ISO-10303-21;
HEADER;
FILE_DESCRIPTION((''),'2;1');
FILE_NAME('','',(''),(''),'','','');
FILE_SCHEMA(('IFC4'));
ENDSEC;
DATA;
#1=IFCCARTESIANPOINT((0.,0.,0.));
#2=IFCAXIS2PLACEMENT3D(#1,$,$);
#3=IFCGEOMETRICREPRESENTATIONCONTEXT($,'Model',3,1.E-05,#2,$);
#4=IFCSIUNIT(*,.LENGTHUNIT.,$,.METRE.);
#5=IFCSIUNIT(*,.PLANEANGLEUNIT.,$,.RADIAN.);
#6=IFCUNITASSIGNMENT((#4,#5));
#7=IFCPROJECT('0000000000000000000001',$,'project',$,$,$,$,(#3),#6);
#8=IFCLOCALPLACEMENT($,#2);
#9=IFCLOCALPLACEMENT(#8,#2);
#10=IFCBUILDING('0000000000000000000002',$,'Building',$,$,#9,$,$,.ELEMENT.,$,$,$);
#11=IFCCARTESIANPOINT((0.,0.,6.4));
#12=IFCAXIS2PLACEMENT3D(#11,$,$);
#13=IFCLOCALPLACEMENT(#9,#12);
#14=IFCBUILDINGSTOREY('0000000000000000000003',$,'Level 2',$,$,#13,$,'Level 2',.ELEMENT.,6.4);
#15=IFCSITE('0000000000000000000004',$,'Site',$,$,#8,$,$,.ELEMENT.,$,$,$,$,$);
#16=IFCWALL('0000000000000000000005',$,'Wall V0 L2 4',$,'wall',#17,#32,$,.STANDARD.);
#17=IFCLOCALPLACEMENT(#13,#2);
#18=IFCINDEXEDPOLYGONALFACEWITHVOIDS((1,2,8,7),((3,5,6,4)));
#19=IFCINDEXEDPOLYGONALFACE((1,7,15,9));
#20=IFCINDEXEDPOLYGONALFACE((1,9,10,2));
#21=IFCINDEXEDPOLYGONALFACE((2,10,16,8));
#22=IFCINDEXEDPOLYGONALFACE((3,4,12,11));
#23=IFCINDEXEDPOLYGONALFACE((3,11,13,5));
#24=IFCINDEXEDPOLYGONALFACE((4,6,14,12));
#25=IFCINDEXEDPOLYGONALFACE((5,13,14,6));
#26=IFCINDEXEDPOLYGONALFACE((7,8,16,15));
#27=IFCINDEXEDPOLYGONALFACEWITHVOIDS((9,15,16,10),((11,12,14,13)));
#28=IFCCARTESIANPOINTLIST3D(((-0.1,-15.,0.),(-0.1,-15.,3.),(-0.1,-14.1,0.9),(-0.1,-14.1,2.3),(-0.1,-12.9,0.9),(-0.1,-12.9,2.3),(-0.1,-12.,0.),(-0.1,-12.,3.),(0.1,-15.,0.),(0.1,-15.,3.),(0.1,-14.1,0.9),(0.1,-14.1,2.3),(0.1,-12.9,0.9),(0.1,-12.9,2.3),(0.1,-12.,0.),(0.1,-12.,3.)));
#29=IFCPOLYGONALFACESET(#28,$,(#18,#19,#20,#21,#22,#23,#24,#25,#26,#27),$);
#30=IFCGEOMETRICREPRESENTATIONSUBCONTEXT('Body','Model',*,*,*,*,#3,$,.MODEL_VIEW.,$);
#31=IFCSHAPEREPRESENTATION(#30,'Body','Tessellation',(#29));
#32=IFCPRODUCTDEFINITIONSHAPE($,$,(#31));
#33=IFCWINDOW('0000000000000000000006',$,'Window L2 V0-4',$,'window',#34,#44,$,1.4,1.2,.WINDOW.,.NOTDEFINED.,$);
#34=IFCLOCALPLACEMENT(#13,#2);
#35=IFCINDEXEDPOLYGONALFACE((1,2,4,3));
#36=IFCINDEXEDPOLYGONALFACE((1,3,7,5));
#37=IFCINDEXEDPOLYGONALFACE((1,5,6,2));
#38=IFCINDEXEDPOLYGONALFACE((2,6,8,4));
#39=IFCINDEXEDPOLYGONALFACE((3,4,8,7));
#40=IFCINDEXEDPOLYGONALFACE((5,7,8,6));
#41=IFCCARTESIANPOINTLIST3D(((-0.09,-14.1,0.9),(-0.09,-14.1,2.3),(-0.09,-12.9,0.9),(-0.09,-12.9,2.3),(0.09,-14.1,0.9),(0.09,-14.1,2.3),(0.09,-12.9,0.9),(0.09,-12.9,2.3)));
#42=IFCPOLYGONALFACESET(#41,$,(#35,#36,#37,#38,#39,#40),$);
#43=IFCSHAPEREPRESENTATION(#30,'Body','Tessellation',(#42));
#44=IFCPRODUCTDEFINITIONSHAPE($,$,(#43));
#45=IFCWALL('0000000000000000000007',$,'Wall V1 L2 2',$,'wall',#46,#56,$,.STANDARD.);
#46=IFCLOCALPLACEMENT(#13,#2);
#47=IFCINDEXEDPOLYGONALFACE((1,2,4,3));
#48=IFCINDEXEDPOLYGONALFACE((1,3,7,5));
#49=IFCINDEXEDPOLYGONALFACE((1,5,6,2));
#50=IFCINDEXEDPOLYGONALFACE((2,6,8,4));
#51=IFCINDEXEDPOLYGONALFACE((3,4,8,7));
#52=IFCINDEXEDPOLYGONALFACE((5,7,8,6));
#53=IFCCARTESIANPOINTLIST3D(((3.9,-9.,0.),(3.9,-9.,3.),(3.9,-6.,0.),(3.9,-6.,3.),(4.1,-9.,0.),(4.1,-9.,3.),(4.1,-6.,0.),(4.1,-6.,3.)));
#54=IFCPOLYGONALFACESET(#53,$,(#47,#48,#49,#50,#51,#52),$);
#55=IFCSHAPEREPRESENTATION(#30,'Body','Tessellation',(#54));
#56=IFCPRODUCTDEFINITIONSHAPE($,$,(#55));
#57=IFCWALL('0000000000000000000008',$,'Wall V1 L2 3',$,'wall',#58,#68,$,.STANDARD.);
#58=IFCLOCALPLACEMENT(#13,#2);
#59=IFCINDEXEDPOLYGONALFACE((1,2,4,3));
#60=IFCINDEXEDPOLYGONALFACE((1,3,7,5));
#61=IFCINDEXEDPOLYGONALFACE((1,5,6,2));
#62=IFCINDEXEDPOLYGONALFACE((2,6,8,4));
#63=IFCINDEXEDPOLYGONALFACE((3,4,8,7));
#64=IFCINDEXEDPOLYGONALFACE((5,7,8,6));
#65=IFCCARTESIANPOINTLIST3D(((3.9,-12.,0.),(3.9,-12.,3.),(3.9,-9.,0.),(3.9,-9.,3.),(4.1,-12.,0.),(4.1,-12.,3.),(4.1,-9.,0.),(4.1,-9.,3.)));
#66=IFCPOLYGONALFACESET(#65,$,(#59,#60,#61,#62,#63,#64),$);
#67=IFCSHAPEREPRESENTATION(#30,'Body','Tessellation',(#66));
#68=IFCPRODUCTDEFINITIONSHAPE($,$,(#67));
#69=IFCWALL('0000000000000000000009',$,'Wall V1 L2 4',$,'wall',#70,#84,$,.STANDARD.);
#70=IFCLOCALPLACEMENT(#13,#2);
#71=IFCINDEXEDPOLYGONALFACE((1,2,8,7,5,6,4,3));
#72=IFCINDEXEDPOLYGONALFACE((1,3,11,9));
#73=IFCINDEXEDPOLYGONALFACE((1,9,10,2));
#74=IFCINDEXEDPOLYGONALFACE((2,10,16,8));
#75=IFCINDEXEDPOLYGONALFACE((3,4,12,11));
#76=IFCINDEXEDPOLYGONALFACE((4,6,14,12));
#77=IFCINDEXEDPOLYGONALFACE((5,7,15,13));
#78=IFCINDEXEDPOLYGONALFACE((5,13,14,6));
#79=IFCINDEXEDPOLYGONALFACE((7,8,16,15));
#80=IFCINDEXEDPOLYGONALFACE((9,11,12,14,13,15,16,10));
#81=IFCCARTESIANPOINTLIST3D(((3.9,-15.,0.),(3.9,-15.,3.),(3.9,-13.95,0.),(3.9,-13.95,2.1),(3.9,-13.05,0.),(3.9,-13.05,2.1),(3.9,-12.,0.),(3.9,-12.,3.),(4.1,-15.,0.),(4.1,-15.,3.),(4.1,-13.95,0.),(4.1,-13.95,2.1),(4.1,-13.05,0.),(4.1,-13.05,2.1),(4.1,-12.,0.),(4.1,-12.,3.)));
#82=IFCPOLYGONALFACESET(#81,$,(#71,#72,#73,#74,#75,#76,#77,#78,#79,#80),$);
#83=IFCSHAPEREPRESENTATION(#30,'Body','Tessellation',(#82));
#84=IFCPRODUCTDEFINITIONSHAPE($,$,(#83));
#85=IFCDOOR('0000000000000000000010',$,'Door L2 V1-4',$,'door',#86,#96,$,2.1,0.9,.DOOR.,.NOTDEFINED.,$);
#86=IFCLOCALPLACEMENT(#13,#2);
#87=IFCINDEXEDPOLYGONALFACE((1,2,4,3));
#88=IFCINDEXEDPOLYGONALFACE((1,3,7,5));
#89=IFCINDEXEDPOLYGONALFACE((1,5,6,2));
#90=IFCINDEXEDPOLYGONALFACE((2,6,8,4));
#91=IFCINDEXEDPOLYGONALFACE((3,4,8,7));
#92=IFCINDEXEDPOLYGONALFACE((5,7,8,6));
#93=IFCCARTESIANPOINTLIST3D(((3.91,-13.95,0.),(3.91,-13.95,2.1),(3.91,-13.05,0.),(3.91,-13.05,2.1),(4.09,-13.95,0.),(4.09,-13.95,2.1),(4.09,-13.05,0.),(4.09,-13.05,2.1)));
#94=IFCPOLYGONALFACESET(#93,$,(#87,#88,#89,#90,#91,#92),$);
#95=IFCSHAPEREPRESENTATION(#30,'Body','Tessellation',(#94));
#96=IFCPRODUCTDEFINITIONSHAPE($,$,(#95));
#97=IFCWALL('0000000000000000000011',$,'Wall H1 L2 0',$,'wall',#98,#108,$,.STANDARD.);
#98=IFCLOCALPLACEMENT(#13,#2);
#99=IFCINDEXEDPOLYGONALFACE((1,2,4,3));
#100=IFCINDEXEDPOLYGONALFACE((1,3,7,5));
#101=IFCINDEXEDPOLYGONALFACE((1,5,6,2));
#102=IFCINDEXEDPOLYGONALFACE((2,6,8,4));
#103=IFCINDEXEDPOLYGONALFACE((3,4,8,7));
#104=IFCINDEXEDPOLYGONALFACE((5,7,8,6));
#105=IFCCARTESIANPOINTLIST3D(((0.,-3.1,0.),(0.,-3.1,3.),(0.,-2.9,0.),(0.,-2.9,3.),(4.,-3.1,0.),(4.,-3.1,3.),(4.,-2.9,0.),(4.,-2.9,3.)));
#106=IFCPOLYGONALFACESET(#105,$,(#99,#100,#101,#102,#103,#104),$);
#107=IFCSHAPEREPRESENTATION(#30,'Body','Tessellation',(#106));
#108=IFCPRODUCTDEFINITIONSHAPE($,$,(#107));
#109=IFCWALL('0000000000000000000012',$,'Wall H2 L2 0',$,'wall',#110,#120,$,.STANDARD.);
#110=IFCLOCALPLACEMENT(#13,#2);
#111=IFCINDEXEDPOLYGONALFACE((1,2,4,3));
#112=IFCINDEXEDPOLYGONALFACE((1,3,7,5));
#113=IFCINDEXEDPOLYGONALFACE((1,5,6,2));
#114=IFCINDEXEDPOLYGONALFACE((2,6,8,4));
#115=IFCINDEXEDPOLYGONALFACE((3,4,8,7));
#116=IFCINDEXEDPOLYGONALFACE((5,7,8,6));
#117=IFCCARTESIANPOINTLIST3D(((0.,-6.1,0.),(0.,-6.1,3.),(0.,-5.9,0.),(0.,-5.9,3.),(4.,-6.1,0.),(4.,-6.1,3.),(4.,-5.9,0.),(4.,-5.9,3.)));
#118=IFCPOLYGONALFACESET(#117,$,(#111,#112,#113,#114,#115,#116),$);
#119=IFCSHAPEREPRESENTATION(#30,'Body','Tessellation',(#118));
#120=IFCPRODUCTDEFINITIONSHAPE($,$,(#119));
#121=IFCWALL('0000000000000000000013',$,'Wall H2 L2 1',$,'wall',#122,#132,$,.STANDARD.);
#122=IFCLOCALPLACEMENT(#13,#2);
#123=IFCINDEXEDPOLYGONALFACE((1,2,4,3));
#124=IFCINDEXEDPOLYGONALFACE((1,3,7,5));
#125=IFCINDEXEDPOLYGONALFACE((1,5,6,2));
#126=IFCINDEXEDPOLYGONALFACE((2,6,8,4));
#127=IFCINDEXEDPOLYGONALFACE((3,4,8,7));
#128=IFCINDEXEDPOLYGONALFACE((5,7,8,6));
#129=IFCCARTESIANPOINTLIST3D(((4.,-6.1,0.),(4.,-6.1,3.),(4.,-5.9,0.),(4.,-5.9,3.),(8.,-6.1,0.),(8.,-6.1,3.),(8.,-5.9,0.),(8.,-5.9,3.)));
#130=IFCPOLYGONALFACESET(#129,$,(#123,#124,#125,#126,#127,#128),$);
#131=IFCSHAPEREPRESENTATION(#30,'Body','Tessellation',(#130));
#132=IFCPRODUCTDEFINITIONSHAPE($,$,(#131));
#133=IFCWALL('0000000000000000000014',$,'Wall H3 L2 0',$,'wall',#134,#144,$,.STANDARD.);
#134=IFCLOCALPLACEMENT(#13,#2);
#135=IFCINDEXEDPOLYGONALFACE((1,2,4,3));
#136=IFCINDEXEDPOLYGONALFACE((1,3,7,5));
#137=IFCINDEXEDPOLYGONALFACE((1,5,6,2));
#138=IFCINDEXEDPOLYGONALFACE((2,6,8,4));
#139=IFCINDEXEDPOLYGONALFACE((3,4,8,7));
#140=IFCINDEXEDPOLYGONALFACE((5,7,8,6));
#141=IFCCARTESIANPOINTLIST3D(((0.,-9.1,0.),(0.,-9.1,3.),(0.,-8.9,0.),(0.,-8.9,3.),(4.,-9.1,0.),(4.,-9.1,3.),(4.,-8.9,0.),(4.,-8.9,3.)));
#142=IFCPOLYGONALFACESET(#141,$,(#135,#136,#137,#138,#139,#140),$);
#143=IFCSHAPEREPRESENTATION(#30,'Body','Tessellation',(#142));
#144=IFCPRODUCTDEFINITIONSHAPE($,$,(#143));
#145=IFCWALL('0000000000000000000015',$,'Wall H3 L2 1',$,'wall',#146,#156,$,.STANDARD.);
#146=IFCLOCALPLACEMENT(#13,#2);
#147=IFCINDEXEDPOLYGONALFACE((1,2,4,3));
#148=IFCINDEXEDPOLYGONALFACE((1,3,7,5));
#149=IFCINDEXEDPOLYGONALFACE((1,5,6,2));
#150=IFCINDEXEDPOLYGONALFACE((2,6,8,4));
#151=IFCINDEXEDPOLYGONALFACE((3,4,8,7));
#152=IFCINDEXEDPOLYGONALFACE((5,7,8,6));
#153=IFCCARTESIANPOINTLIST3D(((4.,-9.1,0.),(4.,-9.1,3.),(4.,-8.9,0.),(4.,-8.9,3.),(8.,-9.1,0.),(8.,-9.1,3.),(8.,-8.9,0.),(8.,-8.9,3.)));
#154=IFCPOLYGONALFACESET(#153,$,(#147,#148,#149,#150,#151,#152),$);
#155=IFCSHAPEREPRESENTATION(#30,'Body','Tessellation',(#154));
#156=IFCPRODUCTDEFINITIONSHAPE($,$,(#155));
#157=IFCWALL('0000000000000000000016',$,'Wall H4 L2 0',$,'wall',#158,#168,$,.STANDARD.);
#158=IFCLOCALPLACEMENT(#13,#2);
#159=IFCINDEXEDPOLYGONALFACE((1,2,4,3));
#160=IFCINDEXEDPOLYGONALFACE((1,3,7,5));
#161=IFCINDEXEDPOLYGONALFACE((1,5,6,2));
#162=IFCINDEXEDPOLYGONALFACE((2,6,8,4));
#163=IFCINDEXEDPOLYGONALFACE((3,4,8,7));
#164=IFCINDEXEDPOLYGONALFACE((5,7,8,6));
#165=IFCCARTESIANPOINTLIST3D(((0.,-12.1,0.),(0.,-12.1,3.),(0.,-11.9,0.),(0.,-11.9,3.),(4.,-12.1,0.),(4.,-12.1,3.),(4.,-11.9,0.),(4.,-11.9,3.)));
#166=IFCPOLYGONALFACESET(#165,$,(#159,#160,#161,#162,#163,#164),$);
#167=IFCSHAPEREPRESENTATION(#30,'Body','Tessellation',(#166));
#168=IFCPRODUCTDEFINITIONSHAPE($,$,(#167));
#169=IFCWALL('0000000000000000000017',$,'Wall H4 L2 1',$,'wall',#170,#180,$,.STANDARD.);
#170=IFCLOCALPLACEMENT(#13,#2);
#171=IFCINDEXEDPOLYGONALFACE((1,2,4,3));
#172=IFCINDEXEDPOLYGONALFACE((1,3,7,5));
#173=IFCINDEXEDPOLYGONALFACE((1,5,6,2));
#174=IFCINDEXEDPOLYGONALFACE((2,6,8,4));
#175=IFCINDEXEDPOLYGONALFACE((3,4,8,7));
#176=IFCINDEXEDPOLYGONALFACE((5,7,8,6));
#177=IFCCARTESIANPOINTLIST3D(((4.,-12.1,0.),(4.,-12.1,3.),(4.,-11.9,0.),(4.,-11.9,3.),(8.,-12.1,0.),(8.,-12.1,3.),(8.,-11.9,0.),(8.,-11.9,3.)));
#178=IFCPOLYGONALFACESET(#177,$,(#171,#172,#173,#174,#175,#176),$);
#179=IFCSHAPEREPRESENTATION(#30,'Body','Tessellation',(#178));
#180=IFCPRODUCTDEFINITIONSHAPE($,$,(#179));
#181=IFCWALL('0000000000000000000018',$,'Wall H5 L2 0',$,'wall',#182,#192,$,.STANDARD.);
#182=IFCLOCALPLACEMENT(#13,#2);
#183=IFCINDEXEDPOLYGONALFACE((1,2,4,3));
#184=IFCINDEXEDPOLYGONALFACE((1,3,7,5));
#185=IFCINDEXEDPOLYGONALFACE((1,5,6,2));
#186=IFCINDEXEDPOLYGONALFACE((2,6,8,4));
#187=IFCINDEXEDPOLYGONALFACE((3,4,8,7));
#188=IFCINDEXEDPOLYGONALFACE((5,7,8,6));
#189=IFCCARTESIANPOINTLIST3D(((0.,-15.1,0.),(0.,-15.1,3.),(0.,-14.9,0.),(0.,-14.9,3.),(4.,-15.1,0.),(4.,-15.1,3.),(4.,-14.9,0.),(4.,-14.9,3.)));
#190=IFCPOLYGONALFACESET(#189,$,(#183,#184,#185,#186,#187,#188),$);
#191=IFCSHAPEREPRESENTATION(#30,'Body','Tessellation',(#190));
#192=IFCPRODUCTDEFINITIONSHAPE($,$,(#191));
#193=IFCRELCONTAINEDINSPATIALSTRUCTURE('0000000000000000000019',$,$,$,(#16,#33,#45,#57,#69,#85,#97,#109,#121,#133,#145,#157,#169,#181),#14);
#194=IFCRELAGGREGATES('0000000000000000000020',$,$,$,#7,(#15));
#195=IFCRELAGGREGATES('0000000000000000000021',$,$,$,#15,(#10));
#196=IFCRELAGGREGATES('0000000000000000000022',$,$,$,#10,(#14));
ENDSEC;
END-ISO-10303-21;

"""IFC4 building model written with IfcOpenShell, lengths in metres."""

from ifc_helpers import new_model, si_unit, frame, frame_2d, origin, origin_2d, place, context, subcontext, project, spatial, rectangle, extrude, element, fill, save


model = new_model("IFC4")

# Units and contexts
model_context = context("Model", 3, precision=1e-05, world=origin())
body_context = subcontext(model_context, "Body", "Model", "MODEL_VIEW")
ifc_project = project(units=[si_unit("LENGTHUNIT", "METRE"), si_unit("PLANEANGLEUNIT", "RADIAN")], contexts=[model_context])

# Site, building, storey
site_placement = place(None, origin())
site = spatial("IfcSite", under=ifc_project, at=site_placement, Name="Site", CompositionType="ELEMENT")
building_placement = place(site_placement, origin())
building = spatial("IfcBuilding", under=site, at=building_placement, Name="Building", CompositionType="ELEMENT")
storey_placement = place(building_placement, frame((0.0, 0.0, 6.4)))
storey = spatial("IfcBuildingStorey", under=building, at=storey_placement, Name="Level 2", LongName="Level 2", CompositionType="ELEMENT", Elevation=6.4)

# Wall, opening, window
wall_1_placement = place(storey_placement, frame((0.0, -12.0, 0.0), z_axis=(0.0, 0.0, 1.0), x_axis=(0.0, -1.0, 0.0)))
wall_1 = element("IfcWall", 1, at=wall_1_placement, inside=storey, Name="Wall V0 L2 4", ObjectType="wall", PredefinedType="STANDARD", context=body_context, shape_type="SweptSolid", body=[
    extrude(rectangle(XDim=3.0, YDim=0.2, at=frame_2d((1.5, 0.0))), origin(), (0.0, 0.0, 1.0), 3.0),
])
opening_1_placement = place(storey_placement, frame((0.0, -13.5, 0.9), z_axis=(0.0, 0.0, 1.0), x_axis=(0.0, -1.0, 0.0)))
opening_1 = element("IfcOpeningElement", 2, at=opening_1_placement, cuts=wall_1, ObjectType="Opening", PredefinedType="OPENING", context=body_context, shape_type="SweptSolid", body=[
    extrude(rectangle(XDim=1.2, YDim=0.22, at=origin_2d()), origin(), (0.0, 0.0, 1.0), 1.4),
])
window_1_placement = place(storey_placement, frame((0.0, -13.5, 0.9), z_axis=(0.0, 0.0, 1.0), x_axis=(0.0, -1.0, 0.0)))
window_1 = element("IfcWindow", 3, at=window_1_placement, inside=storey, Name="Window L2 V0-4", ObjectType="window", OverallHeight=1.4, OverallWidth=1.2, PartitioningType="NOTDEFINED", PredefinedType="WINDOW", context=body_context, shape_type="SweptSolid", body=[
    extrude(rectangle(XDim=1.2, YDim=0.18, at=origin_2d()), origin(), (0.0, 0.0, 1.0), 1.4),
])
fill(opening_1, window_1)

# Walls
for number, where, z_axis, x_axis, name in (
    (4, (4.0, -6.0, 0.0), (0.0, 0.0, 1.0), (0.0, -1.0, 0.0), "Wall V1 L2 2"),
    (5, (4.0, -9.0, 0.0), (0.0, 0.0, 1.0), (0.0, -1.0, 0.0), "Wall V1 L2 3"),
):
    element("IfcWall", number, at=place(storey_placement, frame(where, z_axis=z_axis, x_axis=x_axis)), inside=storey, Name=name, ObjectType="wall", PredefinedType="STANDARD", context=body_context, shape_type="SweptSolid", body=[
        extrude(rectangle(XDim=3.0, YDim=0.2, at=frame_2d((1.5, 0.0))), origin(), (0.0, 0.0, 1.0), 3.0),
    ])

# Wall, opening, door
wall_2_placement = place(storey_placement, frame((4.0, -12.0, 0.0), z_axis=(0.0, 0.0, 1.0), x_axis=(0.0, -1.0, 0.0)))
wall_2 = element("IfcWall", 6, at=wall_2_placement, inside=storey, Name="Wall V1 L2 4", ObjectType="wall", PredefinedType="STANDARD", context=body_context, shape_type="SweptSolid", body=[
    extrude(rectangle(XDim=3.0, YDim=0.2, at=frame_2d((1.5, 0.0))), origin(), (0.0, 0.0, 1.0), 3.0),
])
opening_2_placement = place(storey_placement, frame((4.0, -13.5, 0.0), z_axis=(0.0, 0.0, 1.0), x_axis=(0.0, -1.0, 0.0)))
opening_2 = element("IfcOpeningElement", 7, at=opening_2_placement, cuts=wall_2, ObjectType="Opening", PredefinedType="OPENING", context=body_context, shape_type="SweptSolid", body=[
    extrude(rectangle(XDim=0.9, YDim=0.22, at=origin_2d()), origin(), (0.0, 0.0, 1.0), 2.1),
])
door_placement = place(storey_placement, frame((4.0, -13.5, 0.0), z_axis=(0.0, 0.0, 1.0), x_axis=(0.0, -1.0, 0.0)))
door = element("IfcDoor", 8, at=door_placement, inside=storey, Name="Door L2 V1-4", ObjectType="door", OperationType="NOTDEFINED", OverallHeight=2.1, OverallWidth=0.9, PredefinedType="DOOR", context=body_context, shape_type="SweptSolid", body=[
    extrude(rectangle(XDim=0.9, YDim=0.18, at=origin_2d()), origin(), (0.0, 0.0, 1.0), 2.1),
])
fill(opening_2, door)

# Walls
for number, where, z_axis, x_axis, name in (
    (9, (0.0, -3.0, 0.0), (0.0, 0.0, 1.0), (1.0, 0.0, 0.0), "Wall H1 L2 0"),
    (10, (0.0, -6.0, 0.0), (0.0, 0.0, 1.0), (1.0, 0.0, 0.0), "Wall H2 L2 0"),
    (11, (4.0, -6.0, 0.0), (0.0, 0.0, 1.0), (1.0, 0.0, 0.0), "Wall H2 L2 1"),
    (12, (0.0, -9.0, 0.0), (0.0, 0.0, 1.0), (1.0, 0.0, 0.0), "Wall H3 L2 0"),
    (13, (4.0, -9.0, 0.0), (0.0, 0.0, 1.0), (1.0, 0.0, 0.0), "Wall H3 L2 1"),
    (14, (0.0, -12.0, 0.0), (0.0, 0.0, 1.0), (1.0, 0.0, 0.0), "Wall H4 L2 0"),
    (15, (4.0, -12.0, 0.0), (0.0, 0.0, 1.0), (1.0, 0.0, 0.0), "Wall H4 L2 1"),
    (16, (0.0, -15.0, 0.0), (0.0, 0.0, 1.0), (1.0, 0.0, 0.0), "Wall H5 L2 0"),
):
    element("IfcWall", number, at=place(storey_placement, frame(where, z_axis=z_axis, x_axis=x_axis)), inside=storey, Name=name, ObjectType="wall", PredefinedType="STANDARD", context=body_context, shape_type="SweptSolid", body=[
        extrude(rectangle(XDim=4.0, YDim=0.2, at=frame_2d((2.0, 0.0))), origin(), (0.0, 0.0, 1.0), 3.0),
    ])

save(model, "model.ifc")
